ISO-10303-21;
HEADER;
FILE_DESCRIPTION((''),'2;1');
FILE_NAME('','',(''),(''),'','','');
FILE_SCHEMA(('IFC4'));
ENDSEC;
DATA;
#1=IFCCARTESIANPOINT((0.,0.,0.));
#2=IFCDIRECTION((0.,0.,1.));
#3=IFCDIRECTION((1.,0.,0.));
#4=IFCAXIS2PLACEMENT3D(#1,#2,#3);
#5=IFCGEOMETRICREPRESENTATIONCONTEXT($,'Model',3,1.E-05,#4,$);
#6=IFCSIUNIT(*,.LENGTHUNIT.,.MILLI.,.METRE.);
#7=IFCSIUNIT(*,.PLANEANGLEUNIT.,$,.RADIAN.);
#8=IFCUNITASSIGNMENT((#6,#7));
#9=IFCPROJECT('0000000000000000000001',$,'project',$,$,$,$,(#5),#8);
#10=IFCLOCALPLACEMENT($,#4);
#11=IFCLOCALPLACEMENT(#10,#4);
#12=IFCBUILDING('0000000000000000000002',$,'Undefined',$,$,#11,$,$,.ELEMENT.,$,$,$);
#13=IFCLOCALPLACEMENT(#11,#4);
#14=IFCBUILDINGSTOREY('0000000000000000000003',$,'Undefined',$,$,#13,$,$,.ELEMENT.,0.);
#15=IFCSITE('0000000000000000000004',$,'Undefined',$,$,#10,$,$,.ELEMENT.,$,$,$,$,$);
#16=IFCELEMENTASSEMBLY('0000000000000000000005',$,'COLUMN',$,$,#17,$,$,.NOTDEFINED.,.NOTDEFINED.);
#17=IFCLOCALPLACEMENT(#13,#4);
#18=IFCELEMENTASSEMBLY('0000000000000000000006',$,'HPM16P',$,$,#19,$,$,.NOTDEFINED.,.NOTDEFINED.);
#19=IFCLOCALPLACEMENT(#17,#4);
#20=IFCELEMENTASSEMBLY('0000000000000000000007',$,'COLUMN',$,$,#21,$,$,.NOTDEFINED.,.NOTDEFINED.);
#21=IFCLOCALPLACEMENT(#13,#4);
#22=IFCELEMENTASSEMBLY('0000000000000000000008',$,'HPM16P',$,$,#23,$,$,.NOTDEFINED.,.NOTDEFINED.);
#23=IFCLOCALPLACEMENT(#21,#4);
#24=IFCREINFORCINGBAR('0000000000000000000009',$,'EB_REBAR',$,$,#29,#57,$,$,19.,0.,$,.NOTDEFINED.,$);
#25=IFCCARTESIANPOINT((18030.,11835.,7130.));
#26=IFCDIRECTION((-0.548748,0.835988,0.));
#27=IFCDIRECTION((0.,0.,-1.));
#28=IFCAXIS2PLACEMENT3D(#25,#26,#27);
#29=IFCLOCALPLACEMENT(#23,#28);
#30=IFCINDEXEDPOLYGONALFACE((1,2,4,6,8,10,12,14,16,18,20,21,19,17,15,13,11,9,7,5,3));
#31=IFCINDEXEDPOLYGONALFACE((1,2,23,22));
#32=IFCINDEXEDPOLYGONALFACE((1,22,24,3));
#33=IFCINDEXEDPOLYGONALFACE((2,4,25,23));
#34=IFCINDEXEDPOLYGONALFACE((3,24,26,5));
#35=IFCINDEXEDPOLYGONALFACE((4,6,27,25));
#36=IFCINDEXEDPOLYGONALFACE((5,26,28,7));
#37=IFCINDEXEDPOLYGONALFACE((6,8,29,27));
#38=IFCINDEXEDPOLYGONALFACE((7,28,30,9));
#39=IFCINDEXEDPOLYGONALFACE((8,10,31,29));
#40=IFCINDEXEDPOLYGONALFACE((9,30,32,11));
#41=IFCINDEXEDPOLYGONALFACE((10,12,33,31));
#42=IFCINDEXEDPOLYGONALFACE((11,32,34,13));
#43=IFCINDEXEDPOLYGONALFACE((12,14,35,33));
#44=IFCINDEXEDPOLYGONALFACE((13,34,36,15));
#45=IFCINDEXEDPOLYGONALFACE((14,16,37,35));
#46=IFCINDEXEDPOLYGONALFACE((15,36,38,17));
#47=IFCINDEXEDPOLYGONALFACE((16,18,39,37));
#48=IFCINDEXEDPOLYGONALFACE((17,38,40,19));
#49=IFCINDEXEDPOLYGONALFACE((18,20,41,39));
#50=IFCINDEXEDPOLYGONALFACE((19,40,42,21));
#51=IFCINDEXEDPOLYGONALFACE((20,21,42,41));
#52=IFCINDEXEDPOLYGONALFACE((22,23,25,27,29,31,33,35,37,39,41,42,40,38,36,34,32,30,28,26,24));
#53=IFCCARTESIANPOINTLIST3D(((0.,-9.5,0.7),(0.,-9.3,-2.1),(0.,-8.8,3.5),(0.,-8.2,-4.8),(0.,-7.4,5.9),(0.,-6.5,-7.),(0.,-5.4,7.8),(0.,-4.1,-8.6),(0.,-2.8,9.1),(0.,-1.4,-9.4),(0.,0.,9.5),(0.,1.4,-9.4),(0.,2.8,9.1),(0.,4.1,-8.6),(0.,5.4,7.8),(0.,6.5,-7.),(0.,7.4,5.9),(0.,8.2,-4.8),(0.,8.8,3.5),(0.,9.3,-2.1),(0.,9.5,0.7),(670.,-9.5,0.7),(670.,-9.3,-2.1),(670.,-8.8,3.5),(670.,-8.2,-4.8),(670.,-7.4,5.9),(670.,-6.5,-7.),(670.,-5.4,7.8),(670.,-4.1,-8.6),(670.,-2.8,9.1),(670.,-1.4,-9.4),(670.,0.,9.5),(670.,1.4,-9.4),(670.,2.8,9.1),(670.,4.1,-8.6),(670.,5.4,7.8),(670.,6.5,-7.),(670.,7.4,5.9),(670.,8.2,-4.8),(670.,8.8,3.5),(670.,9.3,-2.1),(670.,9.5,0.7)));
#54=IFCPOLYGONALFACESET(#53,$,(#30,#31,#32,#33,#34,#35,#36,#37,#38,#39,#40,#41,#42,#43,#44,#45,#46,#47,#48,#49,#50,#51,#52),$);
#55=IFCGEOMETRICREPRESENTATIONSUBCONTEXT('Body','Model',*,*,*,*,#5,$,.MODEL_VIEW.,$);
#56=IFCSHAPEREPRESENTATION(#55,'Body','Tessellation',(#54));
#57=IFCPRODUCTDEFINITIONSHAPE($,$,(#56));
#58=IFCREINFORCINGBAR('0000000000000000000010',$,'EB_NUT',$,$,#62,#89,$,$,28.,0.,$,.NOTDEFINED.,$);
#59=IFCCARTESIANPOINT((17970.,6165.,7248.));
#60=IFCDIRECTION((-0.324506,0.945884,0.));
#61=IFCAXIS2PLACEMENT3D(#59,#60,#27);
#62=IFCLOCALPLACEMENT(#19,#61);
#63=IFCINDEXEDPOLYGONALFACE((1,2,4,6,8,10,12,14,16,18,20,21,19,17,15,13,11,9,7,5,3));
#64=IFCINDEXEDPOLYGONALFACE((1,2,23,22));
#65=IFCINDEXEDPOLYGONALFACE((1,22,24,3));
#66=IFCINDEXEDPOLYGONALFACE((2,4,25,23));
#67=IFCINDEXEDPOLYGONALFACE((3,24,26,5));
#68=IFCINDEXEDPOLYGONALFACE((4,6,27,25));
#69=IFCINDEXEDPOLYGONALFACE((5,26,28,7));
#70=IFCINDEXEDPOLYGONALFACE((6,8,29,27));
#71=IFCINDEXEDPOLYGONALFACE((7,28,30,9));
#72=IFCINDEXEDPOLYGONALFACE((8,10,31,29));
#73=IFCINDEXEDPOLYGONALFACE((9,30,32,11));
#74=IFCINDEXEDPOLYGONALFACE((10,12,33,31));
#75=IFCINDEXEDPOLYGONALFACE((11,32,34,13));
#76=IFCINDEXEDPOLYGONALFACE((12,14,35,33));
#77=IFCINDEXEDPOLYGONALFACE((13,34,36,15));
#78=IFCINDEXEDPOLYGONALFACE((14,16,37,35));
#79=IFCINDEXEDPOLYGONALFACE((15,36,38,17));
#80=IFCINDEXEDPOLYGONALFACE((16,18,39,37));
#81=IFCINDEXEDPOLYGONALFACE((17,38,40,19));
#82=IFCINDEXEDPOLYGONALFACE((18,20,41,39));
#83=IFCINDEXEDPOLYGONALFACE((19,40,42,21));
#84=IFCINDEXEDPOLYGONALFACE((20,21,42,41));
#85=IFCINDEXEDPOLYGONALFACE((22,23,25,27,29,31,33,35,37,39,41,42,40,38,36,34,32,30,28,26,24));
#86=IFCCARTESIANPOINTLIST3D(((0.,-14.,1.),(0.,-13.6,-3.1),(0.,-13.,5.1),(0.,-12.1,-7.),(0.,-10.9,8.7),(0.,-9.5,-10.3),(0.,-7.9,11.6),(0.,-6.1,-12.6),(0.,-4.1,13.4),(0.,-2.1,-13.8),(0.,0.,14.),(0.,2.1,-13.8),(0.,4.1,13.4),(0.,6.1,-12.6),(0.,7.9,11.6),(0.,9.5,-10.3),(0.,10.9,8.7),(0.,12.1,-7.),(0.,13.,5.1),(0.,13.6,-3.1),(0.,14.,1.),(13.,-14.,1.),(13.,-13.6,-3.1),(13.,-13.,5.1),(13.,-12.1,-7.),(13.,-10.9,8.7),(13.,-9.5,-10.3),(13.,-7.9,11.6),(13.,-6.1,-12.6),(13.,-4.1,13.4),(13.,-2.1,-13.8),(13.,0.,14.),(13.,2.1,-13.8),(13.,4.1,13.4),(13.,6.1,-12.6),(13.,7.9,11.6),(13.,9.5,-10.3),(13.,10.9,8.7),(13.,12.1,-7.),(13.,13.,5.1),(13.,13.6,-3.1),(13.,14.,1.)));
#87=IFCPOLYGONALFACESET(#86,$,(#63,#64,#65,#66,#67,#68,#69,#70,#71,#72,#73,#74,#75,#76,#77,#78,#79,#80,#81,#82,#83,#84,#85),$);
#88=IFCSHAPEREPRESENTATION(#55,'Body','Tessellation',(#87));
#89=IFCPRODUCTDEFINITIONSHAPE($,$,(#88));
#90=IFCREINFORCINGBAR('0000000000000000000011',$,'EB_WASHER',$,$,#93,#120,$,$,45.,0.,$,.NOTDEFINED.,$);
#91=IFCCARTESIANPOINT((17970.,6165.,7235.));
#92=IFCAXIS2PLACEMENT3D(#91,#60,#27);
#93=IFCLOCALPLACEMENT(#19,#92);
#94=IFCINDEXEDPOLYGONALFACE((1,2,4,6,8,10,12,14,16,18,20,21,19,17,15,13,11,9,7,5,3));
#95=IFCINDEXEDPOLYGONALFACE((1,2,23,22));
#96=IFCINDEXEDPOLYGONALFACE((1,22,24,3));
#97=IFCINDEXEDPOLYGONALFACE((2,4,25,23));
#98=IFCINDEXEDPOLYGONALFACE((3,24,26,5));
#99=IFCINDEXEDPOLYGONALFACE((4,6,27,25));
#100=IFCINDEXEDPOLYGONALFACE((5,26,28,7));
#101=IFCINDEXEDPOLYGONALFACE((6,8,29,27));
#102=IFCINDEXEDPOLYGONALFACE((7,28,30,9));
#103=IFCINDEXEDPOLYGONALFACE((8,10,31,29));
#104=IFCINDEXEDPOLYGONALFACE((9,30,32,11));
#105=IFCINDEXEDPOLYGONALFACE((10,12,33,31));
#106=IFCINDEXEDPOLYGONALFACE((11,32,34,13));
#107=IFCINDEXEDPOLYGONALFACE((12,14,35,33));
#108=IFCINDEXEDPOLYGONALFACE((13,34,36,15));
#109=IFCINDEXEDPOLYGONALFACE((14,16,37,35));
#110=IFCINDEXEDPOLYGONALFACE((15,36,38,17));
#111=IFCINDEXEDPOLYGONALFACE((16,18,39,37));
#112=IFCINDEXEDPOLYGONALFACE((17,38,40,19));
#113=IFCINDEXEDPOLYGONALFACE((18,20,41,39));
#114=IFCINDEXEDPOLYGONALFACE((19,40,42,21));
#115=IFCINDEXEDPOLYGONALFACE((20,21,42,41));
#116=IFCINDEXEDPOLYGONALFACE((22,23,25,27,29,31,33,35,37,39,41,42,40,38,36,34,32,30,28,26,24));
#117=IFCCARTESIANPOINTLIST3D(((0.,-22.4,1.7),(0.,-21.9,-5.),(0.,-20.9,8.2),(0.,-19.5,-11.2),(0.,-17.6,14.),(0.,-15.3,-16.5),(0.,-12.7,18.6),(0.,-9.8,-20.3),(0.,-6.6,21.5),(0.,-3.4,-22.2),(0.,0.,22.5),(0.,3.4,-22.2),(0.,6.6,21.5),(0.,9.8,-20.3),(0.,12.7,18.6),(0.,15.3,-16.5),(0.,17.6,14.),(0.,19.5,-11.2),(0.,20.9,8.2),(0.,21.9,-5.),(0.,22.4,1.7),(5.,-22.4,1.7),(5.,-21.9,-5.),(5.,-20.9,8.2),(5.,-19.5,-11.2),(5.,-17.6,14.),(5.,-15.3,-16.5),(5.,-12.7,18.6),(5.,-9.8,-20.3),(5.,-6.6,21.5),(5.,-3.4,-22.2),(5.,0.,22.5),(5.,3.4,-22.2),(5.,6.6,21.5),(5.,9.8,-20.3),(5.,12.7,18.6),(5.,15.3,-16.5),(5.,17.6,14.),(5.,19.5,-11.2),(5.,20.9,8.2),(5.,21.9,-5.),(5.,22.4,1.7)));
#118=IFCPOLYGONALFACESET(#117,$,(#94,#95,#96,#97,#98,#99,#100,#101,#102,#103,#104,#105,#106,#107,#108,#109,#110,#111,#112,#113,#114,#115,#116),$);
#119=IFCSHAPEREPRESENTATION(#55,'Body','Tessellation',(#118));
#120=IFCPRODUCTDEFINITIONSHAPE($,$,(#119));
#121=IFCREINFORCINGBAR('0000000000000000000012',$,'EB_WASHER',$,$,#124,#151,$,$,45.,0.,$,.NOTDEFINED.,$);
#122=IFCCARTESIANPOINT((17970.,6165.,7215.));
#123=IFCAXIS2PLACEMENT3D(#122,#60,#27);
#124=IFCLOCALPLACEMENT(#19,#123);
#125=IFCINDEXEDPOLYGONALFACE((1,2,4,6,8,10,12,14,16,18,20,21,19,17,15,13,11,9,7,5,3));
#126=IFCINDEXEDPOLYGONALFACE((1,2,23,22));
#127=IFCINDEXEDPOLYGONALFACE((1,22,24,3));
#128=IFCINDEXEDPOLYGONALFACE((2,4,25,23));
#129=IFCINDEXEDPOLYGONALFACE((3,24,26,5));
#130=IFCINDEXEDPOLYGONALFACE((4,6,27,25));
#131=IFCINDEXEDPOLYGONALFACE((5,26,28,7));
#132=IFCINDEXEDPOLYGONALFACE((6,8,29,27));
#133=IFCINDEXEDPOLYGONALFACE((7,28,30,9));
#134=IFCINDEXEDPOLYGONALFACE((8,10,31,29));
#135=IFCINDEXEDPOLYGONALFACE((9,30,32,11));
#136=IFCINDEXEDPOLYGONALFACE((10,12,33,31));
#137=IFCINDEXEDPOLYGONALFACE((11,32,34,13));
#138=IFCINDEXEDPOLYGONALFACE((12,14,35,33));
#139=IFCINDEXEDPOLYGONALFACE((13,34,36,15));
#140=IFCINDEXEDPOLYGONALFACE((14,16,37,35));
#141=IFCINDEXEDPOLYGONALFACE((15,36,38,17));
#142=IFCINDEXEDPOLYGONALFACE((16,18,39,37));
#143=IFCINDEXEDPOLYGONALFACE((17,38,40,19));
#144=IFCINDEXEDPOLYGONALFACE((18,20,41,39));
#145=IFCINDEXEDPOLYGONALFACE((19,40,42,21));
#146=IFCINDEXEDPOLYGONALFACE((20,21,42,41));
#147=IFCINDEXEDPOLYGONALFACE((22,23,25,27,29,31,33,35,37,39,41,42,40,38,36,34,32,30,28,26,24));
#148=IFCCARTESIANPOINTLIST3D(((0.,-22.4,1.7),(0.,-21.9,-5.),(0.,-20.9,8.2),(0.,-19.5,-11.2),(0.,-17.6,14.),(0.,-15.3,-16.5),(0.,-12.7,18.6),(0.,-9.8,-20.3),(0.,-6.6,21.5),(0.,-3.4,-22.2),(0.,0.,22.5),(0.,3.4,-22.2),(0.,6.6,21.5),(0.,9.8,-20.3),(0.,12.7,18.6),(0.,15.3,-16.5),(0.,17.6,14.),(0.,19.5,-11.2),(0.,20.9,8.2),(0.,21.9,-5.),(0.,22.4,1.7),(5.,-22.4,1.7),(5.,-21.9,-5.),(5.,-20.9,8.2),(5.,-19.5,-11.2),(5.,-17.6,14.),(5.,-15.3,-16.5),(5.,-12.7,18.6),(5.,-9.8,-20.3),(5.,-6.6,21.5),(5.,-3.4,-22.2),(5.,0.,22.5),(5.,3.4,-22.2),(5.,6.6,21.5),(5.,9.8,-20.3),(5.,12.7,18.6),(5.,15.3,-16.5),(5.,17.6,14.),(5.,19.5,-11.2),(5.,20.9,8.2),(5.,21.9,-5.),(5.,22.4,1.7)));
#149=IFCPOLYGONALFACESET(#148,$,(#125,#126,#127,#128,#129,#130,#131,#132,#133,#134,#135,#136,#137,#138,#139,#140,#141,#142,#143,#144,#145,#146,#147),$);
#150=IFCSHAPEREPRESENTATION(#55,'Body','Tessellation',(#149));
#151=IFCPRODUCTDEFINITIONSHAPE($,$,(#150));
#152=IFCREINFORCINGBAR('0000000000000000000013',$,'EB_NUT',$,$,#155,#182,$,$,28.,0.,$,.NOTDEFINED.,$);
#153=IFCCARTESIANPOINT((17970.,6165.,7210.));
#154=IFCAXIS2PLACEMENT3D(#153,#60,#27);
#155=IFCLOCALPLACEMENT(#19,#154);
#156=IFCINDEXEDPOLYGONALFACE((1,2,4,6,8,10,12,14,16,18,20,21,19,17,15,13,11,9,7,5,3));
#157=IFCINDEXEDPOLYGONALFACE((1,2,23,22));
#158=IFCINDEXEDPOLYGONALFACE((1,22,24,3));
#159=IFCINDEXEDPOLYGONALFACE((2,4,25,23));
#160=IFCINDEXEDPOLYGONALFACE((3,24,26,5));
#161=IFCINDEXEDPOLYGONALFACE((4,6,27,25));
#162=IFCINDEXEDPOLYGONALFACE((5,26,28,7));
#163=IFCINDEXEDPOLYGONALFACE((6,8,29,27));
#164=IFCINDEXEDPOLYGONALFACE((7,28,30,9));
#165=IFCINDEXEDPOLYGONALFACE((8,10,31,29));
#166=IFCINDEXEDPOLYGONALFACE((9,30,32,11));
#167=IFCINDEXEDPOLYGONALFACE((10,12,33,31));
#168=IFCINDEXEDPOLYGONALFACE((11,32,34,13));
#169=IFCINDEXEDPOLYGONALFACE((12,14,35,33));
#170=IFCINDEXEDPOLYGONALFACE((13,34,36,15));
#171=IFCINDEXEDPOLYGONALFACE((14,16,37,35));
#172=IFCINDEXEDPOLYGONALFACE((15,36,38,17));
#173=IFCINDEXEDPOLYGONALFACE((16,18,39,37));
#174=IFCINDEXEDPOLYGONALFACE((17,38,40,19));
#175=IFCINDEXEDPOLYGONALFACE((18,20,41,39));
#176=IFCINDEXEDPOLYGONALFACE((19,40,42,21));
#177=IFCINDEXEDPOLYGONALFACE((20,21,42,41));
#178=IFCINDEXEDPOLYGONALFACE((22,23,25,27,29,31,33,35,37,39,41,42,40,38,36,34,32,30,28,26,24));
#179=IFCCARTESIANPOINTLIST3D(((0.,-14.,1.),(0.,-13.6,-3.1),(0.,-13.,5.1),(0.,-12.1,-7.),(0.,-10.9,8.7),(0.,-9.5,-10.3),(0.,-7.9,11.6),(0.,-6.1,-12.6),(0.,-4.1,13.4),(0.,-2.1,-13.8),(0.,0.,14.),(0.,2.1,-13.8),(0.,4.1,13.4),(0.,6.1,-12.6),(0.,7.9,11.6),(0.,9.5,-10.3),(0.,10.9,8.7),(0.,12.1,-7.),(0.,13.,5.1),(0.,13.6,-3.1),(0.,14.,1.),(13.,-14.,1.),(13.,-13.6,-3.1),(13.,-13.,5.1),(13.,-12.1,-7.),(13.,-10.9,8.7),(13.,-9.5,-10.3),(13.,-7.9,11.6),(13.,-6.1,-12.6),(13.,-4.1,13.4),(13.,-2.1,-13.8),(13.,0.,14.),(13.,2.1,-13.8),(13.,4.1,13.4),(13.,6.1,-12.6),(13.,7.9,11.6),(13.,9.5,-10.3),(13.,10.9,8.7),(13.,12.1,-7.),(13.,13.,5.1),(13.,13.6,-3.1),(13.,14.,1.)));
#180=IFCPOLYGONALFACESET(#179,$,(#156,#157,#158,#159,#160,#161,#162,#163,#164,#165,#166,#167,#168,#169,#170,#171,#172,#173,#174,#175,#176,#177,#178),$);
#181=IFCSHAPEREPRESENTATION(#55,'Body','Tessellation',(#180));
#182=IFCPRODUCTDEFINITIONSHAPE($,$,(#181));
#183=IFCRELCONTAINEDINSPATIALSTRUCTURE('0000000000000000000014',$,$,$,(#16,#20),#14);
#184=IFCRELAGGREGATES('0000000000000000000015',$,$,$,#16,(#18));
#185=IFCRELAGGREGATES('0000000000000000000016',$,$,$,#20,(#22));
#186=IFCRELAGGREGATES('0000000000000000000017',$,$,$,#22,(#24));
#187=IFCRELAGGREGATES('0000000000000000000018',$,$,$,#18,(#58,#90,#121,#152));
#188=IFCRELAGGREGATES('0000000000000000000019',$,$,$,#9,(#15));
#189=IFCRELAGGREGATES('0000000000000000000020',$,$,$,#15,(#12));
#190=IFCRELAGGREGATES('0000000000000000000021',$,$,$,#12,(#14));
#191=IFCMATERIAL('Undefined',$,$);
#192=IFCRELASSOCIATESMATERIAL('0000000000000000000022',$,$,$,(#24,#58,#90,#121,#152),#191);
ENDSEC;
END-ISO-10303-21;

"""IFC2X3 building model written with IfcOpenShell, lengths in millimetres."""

from ifc_helpers import new_model, entity, si_unit, frame, origin_with_axes, place, context, subcontext, project, spatial, source, transform, mapped, material, element, aggregate, save


model = new_model("IFC2X3")

# Units and contexts
model_context = context("Model", 3, precision=1e-05, world=origin_with_axes())
body_context = subcontext(model_context, "Body", "Model", "MODEL_VIEW")
ifc_project = project(units=[si_unit("LENGTHUNIT", "METRE", prefix="MILLI"), si_unit("PLANEANGLEUNIT", "RADIAN")], contexts=[model_context])

# Site, building, storey
site_placement = place(None, origin_with_axes())
site = spatial("IfcSite", under=ifc_project, at=site_placement, Name="Undefined", CompositionType="ELEMENT")
building_placement = place(site_placement, origin_with_axes())
building = spatial("IfcBuilding", under=site, at=building_placement, Name="Undefined", CompositionType="ELEMENT")
storey_placement = place(building_placement, origin_with_axes())
storey = spatial("IfcBuildingStorey", under=building, at=storey_placement, Name="Undefined", CompositionType="ELEMENT", Elevation=0.0)

# Element assemblies
assembly_1_placement = place(storey_placement, origin_with_axes())
assembly_1 = element("IfcElementAssembly", 1, at=assembly_1_placement, inside=storey, Name="COLUMN", AssemblyPlace="NOTDEFINED", PredefinedType="NOTDEFINED")
assembly_2_placement = place(assembly_1_placement, origin_with_axes())
assembly_2 = element("IfcElementAssembly", 2, at=assembly_2_placement, Name="HPM16P", AssemblyPlace="NOTDEFINED", PredefinedType="NOTDEFINED")

aggregate(assembly_1, [assembly_2])

# Element assembly
assembly_3_placement = place(storey_placement, origin_with_axes())
assembly_3 = element("IfcElementAssembly", 3, at=assembly_3_placement, inside=storey, Name="COLUMN", AssemblyPlace="NOTDEFINED", PredefinedType="NOTDEFINED")

# Shared definitions
ifc_material_1 = material(Name="Undefined")

# Element assembly
assembly_4_placement = place(assembly_3_placement, origin_with_axes())
assembly_4 = element("IfcElementAssembly", 4, at=assembly_4_placement, Name="HPM16P", AssemblyPlace="NOTDEFINED", PredefinedType="NOTDEFINED")
aggregate(assembly_3, [assembly_4])

# Reinforcing bar
shared_shape_1 = source(origin_with_axes(), body_context, "Body", "AdvancedSweptSolid", [
    entity("IfcSweptDiskSolid", entity("IfcTrimmedCurve", entity("IfcLine", entity("IfcCartesianPoint", [0.0, 0.0, 0.0]), entity("IfcVector", entity("IfcDirection", [1.0, 0.0, 0.0]), 1.0)), [entity("IfcParameterValue", 0.0)], [entity("IfcParameterValue", 670.0)], True, "PARAMETER"), 9.5, None, 0.0, 670.0),
])
reinforcing_bar_1_placement = place(assembly_4_placement, frame((18030.0, 11835.0, 7130.0), z_axis=(-0.548748, 0.835988, 0.0), x_axis=(0.0, 0.0, -1.0)))
reinforcing_bar_1 = element("IfcReinforcingBar", 5, at=reinforcing_bar_1_placement, material=ifc_material_1, Name="EB_REBAR", BarRole="NOTDEFINED", CrossSectionArea=0.0, NominalDiameter=19.0, context=body_context, shape_type="MappedRepresentation", body=[
    mapped(shared_shape_1, transform((0.0, 0.0, 0.0))),
])
aggregate(assembly_4, [reinforcing_bar_1])

# Reinforcing bars
shared_shape_2 = source(origin_with_axes(), body_context, "Body", "AdvancedSweptSolid", [
    entity("IfcSweptDiskSolid", entity("IfcTrimmedCurve", entity("IfcLine", entity("IfcCartesianPoint", [0.0, 0.0, 0.0]), entity("IfcVector", entity("IfcDirection", [1.0, 0.0, 0.0]), 1.0)), [entity("IfcParameterValue", 0.0)], [entity("IfcParameterValue", 13.0)], True, "PARAMETER"), 14.0, None, 0.0, 13.0),
])
reinforcing_bar_2_placement = place(assembly_2_placement, frame((17970.0, 6165.0, 7248.0), z_axis=(-0.324506, 0.945884, 0.0), x_axis=(0.0, 0.0, -1.0)))
reinforcing_bar_2 = element("IfcReinforcingBar", 6, at=reinforcing_bar_2_placement, material=ifc_material_1, Name="EB_NUT", BarRole="NOTDEFINED", CrossSectionArea=0.0, NominalDiameter=28.0, context=body_context, shape_type="MappedRepresentation", body=[
    mapped(shared_shape_2, transform((0.0, 0.0, 0.0))),
])
shared_shape_3 = source(origin_with_axes(), body_context, "Body", "AdvancedSweptSolid", [
    entity("IfcSweptDiskSolid", entity("IfcTrimmedCurve", entity("IfcLine", entity("IfcCartesianPoint", [0.0, 0.0, 0.0]), entity("IfcVector", entity("IfcDirection", [1.0, 0.0, 0.0]), 1.0)), [entity("IfcParameterValue", 0.0)], [entity("IfcParameterValue", 5.0)], True, "PARAMETER"), 22.5, None, 0.0, 5.0),
])
reinforcing_bar_3_placement = place(assembly_2_placement, frame((17970.0, 6165.0, 7235.0), z_axis=(-0.324506, 0.945884, 0.0), x_axis=(0.0, 0.0, -1.0)))
reinforcing_bar_3 = element("IfcReinforcingBar", 7, at=reinforcing_bar_3_placement, material=ifc_material_1, Name="EB_WASHER", BarRole="NOTDEFINED", CrossSectionArea=0.0, NominalDiameter=45.0, context=body_context, shape_type="MappedRepresentation", body=[
    mapped(shared_shape_3, transform((0.0, 0.0, 0.0))),
])
shared_shape_4 = source(origin_with_axes(), body_context, "Body", "AdvancedSweptSolid", [
    entity("IfcSweptDiskSolid", entity("IfcTrimmedCurve", entity("IfcLine", entity("IfcCartesianPoint", [0.0, 0.0, 0.0]), entity("IfcVector", entity("IfcDirection", [1.0, 0.0, 0.0]), 1.0)), [entity("IfcParameterValue", 0.0)], [entity("IfcParameterValue", 5.0)], True, "PARAMETER"), 22.5, None, 0.0, 5.0),
])
reinforcing_bar_4_placement = place(assembly_2_placement, frame((17970.0, 6165.0, 7215.0), z_axis=(-0.324506, 0.945884, 0.0), x_axis=(0.0, 0.0, -1.0)))
reinforcing_bar_4 = element("IfcReinforcingBar", 8, at=reinforcing_bar_4_placement, material=ifc_material_1, Name="EB_WASHER", BarRole="NOTDEFINED", CrossSectionArea=0.0, NominalDiameter=45.0, context=body_context, shape_type="MappedRepresentation", body=[
    mapped(shared_shape_4, transform((0.0, 0.0, 0.0))),
])
shared_shape_5 = source(origin_with_axes(), body_context, "Body", "AdvancedSweptSolid", [
    entity("IfcSweptDiskSolid", entity("IfcTrimmedCurve", entity("IfcLine", entity("IfcCartesianPoint", [0.0, 0.0, 0.0]), entity("IfcVector", entity("IfcDirection", [1.0, 0.0, 0.0]), 1.0)), [entity("IfcParameterValue", 0.0)], [entity("IfcParameterValue", 13.0)], True, "PARAMETER"), 14.0, None, 0.0, 13.0),
])
reinforcing_bar_5_placement = place(assembly_2_placement, frame((17970.0, 6165.0, 7210.0), z_axis=(-0.324506, 0.945884, 0.0), x_axis=(0.0, 0.0, -1.0)))
reinforcing_bar_5 = element("IfcReinforcingBar", 9, at=reinforcing_bar_5_placement, material=ifc_material_1, Name="EB_NUT", BarRole="NOTDEFINED", CrossSectionArea=0.0, NominalDiameter=28.0, context=body_context, shape_type="MappedRepresentation", body=[
    mapped(shared_shape_5, transform((0.0, 0.0, 0.0))),
])
aggregate(assembly_2, [reinforcing_bar_2, reinforcing_bar_3, reinforcing_bar_4, reinforcing_bar_5])

save(model, "model.ifc")
